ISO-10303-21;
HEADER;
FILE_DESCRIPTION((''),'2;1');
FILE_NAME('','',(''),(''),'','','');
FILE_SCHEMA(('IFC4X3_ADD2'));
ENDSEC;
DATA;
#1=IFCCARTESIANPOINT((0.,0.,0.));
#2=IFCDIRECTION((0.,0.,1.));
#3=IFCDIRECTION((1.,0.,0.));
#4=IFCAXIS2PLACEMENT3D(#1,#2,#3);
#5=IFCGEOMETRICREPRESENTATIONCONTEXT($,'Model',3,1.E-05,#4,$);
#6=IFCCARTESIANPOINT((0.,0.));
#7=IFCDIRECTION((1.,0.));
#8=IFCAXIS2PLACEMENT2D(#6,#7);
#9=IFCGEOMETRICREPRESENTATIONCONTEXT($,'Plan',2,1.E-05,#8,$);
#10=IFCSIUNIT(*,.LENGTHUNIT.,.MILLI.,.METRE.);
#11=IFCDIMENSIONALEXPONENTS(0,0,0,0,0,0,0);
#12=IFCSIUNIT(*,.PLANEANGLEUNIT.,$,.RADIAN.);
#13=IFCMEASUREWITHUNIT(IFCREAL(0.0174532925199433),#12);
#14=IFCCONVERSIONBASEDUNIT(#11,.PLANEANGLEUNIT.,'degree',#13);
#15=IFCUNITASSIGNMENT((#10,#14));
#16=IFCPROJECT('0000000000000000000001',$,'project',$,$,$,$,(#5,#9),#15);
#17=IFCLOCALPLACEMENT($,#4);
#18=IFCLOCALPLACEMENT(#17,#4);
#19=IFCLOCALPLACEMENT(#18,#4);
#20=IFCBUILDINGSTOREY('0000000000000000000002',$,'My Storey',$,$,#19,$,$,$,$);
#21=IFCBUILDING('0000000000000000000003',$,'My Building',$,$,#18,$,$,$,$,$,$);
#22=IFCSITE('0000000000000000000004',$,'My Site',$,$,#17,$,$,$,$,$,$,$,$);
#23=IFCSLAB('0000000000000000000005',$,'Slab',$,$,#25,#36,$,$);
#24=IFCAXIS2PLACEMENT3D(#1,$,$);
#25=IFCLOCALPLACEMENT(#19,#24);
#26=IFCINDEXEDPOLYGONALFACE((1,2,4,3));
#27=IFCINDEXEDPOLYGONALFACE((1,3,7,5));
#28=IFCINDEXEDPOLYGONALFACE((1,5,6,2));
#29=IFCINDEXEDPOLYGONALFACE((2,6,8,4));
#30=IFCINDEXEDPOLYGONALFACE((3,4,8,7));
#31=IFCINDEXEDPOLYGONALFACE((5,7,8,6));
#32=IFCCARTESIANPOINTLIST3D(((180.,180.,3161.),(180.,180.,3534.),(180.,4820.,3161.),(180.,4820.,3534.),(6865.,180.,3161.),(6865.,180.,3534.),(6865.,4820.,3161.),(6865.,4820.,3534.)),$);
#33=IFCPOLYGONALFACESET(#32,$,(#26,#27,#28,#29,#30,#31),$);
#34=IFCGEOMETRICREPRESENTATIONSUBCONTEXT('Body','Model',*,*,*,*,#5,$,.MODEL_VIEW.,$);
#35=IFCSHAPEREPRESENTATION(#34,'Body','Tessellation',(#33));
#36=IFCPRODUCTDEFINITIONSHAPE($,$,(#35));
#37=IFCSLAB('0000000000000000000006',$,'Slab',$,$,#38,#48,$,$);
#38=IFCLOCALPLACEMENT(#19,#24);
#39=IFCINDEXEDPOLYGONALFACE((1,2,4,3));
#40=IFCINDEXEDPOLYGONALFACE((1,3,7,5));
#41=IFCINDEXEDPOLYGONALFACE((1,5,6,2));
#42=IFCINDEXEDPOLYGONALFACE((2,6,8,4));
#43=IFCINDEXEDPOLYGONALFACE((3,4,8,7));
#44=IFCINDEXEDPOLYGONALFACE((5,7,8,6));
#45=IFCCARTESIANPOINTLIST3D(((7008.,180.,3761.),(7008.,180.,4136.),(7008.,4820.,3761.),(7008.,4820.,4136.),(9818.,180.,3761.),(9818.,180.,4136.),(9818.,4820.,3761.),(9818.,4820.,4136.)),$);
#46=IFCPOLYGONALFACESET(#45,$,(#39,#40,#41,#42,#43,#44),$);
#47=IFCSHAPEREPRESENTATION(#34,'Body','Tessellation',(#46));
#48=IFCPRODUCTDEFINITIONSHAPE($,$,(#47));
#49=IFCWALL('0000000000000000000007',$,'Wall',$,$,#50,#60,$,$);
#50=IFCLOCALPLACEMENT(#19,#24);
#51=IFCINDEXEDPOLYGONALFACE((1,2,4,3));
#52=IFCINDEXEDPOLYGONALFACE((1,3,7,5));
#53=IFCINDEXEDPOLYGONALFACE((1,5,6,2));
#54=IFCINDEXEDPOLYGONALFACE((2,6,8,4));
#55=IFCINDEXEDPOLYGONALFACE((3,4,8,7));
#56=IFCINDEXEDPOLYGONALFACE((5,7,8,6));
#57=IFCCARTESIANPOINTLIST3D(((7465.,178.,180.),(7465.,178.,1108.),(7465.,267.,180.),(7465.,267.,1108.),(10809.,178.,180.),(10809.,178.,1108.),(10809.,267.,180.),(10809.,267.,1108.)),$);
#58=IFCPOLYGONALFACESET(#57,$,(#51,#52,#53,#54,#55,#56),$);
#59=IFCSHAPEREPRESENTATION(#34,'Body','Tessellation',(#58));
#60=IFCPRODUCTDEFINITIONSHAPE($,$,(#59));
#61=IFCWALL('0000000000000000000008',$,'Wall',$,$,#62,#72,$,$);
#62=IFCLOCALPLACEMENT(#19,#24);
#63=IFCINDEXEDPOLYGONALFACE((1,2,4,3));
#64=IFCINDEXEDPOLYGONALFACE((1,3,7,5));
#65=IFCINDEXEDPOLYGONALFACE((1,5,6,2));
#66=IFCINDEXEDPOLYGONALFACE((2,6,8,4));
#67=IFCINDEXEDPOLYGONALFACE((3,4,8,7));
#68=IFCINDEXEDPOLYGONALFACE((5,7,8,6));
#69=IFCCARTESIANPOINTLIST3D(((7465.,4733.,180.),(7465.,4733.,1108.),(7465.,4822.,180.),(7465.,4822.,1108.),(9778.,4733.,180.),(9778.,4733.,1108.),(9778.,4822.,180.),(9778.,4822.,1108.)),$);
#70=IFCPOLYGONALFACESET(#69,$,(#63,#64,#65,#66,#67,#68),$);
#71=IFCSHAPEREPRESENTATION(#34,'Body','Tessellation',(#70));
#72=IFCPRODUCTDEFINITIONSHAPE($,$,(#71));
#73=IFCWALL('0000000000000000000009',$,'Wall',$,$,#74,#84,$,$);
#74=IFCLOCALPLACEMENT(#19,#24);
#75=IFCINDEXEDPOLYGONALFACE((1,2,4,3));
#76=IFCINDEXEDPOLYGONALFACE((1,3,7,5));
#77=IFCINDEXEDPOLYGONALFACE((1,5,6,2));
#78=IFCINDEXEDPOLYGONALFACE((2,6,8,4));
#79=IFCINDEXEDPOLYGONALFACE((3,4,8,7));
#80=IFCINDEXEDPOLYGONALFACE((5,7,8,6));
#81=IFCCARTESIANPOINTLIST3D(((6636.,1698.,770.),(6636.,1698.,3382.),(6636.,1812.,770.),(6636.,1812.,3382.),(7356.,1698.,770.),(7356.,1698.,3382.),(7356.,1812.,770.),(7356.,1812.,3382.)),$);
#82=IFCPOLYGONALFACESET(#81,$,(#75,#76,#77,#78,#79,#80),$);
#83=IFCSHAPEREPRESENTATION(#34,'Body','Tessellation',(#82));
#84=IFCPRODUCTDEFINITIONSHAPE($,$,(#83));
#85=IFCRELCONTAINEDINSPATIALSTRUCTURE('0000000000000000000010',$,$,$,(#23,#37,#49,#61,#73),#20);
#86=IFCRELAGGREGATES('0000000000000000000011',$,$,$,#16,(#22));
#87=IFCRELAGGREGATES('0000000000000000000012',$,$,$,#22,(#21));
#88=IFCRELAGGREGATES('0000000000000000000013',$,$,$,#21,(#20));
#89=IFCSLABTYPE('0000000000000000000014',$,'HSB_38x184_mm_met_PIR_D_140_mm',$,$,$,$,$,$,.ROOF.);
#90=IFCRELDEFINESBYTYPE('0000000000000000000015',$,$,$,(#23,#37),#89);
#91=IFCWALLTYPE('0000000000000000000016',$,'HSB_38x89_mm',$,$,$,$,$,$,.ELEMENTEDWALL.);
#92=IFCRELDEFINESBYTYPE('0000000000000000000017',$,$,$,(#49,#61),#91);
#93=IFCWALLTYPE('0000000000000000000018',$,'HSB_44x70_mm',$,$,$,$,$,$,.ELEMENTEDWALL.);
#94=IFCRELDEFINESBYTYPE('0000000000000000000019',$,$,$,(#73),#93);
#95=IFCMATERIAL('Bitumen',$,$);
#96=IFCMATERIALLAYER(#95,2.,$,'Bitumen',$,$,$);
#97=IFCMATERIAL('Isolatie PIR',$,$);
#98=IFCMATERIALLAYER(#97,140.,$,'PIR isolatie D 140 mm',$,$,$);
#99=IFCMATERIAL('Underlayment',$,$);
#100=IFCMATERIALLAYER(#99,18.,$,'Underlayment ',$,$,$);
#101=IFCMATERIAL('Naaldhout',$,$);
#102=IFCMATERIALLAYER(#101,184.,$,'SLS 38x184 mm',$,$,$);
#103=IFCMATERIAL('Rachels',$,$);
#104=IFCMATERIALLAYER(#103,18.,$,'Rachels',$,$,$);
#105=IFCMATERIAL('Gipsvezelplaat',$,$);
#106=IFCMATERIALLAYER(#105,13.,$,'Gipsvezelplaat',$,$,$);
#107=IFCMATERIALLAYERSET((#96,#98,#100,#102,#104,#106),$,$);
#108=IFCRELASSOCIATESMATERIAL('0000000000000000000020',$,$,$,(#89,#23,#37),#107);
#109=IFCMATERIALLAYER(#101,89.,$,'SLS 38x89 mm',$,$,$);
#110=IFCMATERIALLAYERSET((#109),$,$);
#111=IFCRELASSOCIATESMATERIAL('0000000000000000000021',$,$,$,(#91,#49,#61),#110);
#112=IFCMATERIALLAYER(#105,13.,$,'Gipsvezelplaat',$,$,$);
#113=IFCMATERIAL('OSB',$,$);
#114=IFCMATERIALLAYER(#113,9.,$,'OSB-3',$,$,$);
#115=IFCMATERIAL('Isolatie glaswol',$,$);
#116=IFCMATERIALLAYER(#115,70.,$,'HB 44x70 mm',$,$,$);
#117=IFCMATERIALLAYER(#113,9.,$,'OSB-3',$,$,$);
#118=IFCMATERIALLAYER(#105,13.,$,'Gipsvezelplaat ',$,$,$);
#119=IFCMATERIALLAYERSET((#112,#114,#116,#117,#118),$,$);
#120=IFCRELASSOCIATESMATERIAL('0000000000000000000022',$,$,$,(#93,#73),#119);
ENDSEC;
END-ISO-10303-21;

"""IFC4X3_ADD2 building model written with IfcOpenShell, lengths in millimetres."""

from ifc_helpers import new_model, entity, si_unit, converted_unit, frame, origin_with_axes, origin_2d_with_axis, place, context, subcontext, project, spatial, line, indexed_curve, outline, extrude, material, layer, layer_set, layer_usage, type_object, element, save


model = new_model("IFC4X3_ADD2")

# Units and contexts
model_context = context("Model", 3, precision=1e-05, world=origin_with_axes())
plan_context = context("Plan", 2, precision=1e-05, world=origin_2d_with_axis())
body_context_1 = subcontext(model_context, "Body", "Model", "MODEL_VIEW")
ifc_project = project(units=[si_unit("LENGTHUNIT", "METRE", prefix="MILLI"), converted_unit("PLANEANGLEUNIT", "degree", entity("IfcReal", 0.0174532925199433), si_unit("PLANEANGLEUNIT", "RADIAN"), dimensions=[0, 0, 0, 0, 0, 0, 0])], contexts=[model_context, plan_context])

# Site, building, storey
site_placement = place(None, origin_with_axes())
site = spatial("IfcSite", under=ifc_project, at=site_placement, Name="My Site")
building_placement = place(site_placement, origin_with_axes())
building = spatial("IfcBuilding", under=site, at=building_placement, Name="My Building")
storey_placement = place(building_placement, origin_with_axes())
storey = spatial("IfcBuildingStorey", under=building, at=storey_placement, Name="My Storey")

# Slabs
ifc_material_1 = material(Name="Underlayment")
ifc_material_2 = material(Name="Isolatie glaswol")
ifc_material_3 = material(Name="Bitumen")
ifc_layer_1 = layer(ifc_material_3, 2.0, Name="Bitumen")
ifc_material_4 = material(Name="Isolatie PIR")
ifc_layer_2 = layer(ifc_material_4, 140.0, Name="PIR isolatie D 140 mm")
ifc_layer_3 = layer(ifc_material_1, 18.0, Name="Underlayment ")
ifc_material_5 = material(Name="Naaldhout")
ifc_layer_4 = layer(ifc_material_5, 184.0, Name="SLS 38x184 mm")
ifc_material_6 = material(Name="Rachels")
ifc_layer_5 = layer(ifc_material_6, 18.0, Name="Rachels")
ifc_material_7 = material(Name="Gipsvezelplaat")
ifc_layer_6 = layer(ifc_material_7, 13.0, Name="Gipsvezelplaat")
ifc_layer_set_1 = layer_set([ifc_layer_1, ifc_layer_2, ifc_layer_3, ifc_layer_4, ifc_layer_5, ifc_layer_6])
ifc_layer_usage_1 = layer_usage(ifc_layer_set_1, "AXIS3", "POSITIVE", 0.0)
slab_type_1 = type_object("IfcSlabType", Name="HSB_38x184_mm_met_PIR_D_140_mm", PredefinedType="ROOF", material=ifc_layer_set_1)
slab_1_placement = place(storey_placement, frame((180.0, 180.0, 3161.0), z_axis=(0.0, 0.0, 1.0), x_axis=(1.0, 0.0, 0.0)))
element("IfcSlab", 1, at=slab_1_placement, inside=storey, type_object=slab_type_1, material=ifc_layer_usage_1, Name="Slab", context=body_context_1, shape_type="SweptSolid", body=[
    extrude(outline(indexed_curve([(6685.0, 4640.0), (6685.0, 0.0), (0.0, 0.0), (0.0, 4640.0)], segments=[line(3, 2), line(2, 1), line(1, 4), line(4, 3)], self_intersect=False)), None, (0.0, 0.0, 1.0), 373.0),
])
ifc_layer_usage_2 = layer_usage(ifc_layer_set_1, "AXIS3", "POSITIVE", 0.0)
slab_2_placement = place(storey_placement, frame((7008.0, 180.0, 3761.0), z_axis=(0.0, 0.0, 1.0), x_axis=(1.0, 0.0, 0.0)))
element("IfcSlab", 2, at=slab_2_placement, inside=storey, type_object=slab_type_1, material=ifc_layer_usage_2, Name="Slab", context=body_context_1, shape_type="SweptSolid", body=[
    extrude(outline(indexed_curve([(0.0, 0.0), (2810.0, 0.0), (2810.0, 4640.0), (0.0, 4640.0)], segments=[line(4, 1), line(1, 2), line(2, 3), line(3, 4)], self_intersect=False)), None, (0.0, 0.0, 1.0), 375.0),
])

# Shared definitions
ifc_material_8 = material(Name="OSB")

# Walls
ifc_layer_7 = layer(ifc_material_5, 89.0, Name="SLS 38x89 mm")
ifc_layer_set_2 = layer_set([ifc_layer_7])
ifc_layer_usage_3 = layer_usage(ifc_layer_set_2, "AXIS2", "POSITIVE", 0.0)
wall_type_1 = type_object("IfcWallType", Name="HSB_38x89_mm", PredefinedType="ELEMENTEDWALL", material=ifc_layer_set_2)
wall_1_placement = place(storey_placement, frame((7465.0, 178.0, 180.0), z_axis=(0.0, 0.0, 1.0), x_axis=(1.0, 0.0, 0.0)))
element("IfcWall", 3, at=wall_1_placement, inside=storey, type_object=wall_type_1, material=ifc_layer_usage_3, Name="Wall", context=body_context_1, shape_type="SweptSolid", body=[
    extrude(outline(indexed_curve([(0.0, 0.0), (0.0, 89.0), (3344.0, 89.0), (3344.0, 0.0), (0.0, 0.0)], self_intersect=False)), origin_with_axes(), (0.0, 0.0, 1.0), 928.0),
])
ifc_layer_usage_4 = layer_usage(ifc_layer_set_2, "AXIS2", "POSITIVE", 0.0)
wall_2_placement = place(storey_placement, frame((7465.0, 4733.0, 180.0), z_axis=(0.0, 0.0, 1.0), x_axis=(1.0, 0.0, 0.0)))
element("IfcWall", 4, at=wall_2_placement, inside=storey, type_object=wall_type_1, material=ifc_layer_usage_4, Name="Wall", context=body_context_1, shape_type="SweptSolid", body=[
    extrude(outline(indexed_curve([(0.0, 0.0), (0.0, 89.0), (2313.0, 89.0), (2313.0, 0.0), (0.0, 0.0)], self_intersect=False)), origin_with_axes(), (0.0, 0.0, 1.0), 928.0),
])
ifc_layer_8 = layer(ifc_material_7, 13.0, Name="Gipsvezelplaat")
ifc_layer_9 = layer(ifc_material_8, 9.0, Name="OSB-3")
ifc_layer_10 = layer(ifc_material_2, 70.0, Name="HB 44x70 mm")
ifc_layer_11 = layer(ifc_material_8, 9.0, Name="OSB-3")
ifc_layer_12 = layer(ifc_material_7, 13.0, Name="Gipsvezelplaat ")
ifc_layer_set_3 = layer_set([ifc_layer_8, ifc_layer_9, ifc_layer_10, ifc_layer_11, ifc_layer_12])
ifc_layer_usage_5 = layer_usage(ifc_layer_set_3, "AXIS2", "POSITIVE", 0.0)
wall_type_2 = type_object("IfcWallType", Name="HSB_44x70_mm", PredefinedType="ELEMENTEDWALL", material=ifc_layer_set_3)
wall_3_placement = place(storey_placement, frame((6636.0, 1698.0, 770.0), z_axis=(0.0, 0.0, 1.0), x_axis=(1.0, 0.0, 0.0)))
element("IfcWall", 5, at=wall_3_placement, inside=storey, type_object=wall_type_2, material=ifc_layer_usage_5, Name="Wall", context=body_context_1, shape_type="SweptSolid", body=[
    extrude(outline(indexed_curve([(0.0, 0.0), (0.0, 114.0), (720.0, 114.0), (720.0, 0.0), (0.0, 0.0)], self_intersect=False)), origin_with_axes(), (0.0, 0.0, 1.0), 2612.0),
])

save(model, "model.ifc")
